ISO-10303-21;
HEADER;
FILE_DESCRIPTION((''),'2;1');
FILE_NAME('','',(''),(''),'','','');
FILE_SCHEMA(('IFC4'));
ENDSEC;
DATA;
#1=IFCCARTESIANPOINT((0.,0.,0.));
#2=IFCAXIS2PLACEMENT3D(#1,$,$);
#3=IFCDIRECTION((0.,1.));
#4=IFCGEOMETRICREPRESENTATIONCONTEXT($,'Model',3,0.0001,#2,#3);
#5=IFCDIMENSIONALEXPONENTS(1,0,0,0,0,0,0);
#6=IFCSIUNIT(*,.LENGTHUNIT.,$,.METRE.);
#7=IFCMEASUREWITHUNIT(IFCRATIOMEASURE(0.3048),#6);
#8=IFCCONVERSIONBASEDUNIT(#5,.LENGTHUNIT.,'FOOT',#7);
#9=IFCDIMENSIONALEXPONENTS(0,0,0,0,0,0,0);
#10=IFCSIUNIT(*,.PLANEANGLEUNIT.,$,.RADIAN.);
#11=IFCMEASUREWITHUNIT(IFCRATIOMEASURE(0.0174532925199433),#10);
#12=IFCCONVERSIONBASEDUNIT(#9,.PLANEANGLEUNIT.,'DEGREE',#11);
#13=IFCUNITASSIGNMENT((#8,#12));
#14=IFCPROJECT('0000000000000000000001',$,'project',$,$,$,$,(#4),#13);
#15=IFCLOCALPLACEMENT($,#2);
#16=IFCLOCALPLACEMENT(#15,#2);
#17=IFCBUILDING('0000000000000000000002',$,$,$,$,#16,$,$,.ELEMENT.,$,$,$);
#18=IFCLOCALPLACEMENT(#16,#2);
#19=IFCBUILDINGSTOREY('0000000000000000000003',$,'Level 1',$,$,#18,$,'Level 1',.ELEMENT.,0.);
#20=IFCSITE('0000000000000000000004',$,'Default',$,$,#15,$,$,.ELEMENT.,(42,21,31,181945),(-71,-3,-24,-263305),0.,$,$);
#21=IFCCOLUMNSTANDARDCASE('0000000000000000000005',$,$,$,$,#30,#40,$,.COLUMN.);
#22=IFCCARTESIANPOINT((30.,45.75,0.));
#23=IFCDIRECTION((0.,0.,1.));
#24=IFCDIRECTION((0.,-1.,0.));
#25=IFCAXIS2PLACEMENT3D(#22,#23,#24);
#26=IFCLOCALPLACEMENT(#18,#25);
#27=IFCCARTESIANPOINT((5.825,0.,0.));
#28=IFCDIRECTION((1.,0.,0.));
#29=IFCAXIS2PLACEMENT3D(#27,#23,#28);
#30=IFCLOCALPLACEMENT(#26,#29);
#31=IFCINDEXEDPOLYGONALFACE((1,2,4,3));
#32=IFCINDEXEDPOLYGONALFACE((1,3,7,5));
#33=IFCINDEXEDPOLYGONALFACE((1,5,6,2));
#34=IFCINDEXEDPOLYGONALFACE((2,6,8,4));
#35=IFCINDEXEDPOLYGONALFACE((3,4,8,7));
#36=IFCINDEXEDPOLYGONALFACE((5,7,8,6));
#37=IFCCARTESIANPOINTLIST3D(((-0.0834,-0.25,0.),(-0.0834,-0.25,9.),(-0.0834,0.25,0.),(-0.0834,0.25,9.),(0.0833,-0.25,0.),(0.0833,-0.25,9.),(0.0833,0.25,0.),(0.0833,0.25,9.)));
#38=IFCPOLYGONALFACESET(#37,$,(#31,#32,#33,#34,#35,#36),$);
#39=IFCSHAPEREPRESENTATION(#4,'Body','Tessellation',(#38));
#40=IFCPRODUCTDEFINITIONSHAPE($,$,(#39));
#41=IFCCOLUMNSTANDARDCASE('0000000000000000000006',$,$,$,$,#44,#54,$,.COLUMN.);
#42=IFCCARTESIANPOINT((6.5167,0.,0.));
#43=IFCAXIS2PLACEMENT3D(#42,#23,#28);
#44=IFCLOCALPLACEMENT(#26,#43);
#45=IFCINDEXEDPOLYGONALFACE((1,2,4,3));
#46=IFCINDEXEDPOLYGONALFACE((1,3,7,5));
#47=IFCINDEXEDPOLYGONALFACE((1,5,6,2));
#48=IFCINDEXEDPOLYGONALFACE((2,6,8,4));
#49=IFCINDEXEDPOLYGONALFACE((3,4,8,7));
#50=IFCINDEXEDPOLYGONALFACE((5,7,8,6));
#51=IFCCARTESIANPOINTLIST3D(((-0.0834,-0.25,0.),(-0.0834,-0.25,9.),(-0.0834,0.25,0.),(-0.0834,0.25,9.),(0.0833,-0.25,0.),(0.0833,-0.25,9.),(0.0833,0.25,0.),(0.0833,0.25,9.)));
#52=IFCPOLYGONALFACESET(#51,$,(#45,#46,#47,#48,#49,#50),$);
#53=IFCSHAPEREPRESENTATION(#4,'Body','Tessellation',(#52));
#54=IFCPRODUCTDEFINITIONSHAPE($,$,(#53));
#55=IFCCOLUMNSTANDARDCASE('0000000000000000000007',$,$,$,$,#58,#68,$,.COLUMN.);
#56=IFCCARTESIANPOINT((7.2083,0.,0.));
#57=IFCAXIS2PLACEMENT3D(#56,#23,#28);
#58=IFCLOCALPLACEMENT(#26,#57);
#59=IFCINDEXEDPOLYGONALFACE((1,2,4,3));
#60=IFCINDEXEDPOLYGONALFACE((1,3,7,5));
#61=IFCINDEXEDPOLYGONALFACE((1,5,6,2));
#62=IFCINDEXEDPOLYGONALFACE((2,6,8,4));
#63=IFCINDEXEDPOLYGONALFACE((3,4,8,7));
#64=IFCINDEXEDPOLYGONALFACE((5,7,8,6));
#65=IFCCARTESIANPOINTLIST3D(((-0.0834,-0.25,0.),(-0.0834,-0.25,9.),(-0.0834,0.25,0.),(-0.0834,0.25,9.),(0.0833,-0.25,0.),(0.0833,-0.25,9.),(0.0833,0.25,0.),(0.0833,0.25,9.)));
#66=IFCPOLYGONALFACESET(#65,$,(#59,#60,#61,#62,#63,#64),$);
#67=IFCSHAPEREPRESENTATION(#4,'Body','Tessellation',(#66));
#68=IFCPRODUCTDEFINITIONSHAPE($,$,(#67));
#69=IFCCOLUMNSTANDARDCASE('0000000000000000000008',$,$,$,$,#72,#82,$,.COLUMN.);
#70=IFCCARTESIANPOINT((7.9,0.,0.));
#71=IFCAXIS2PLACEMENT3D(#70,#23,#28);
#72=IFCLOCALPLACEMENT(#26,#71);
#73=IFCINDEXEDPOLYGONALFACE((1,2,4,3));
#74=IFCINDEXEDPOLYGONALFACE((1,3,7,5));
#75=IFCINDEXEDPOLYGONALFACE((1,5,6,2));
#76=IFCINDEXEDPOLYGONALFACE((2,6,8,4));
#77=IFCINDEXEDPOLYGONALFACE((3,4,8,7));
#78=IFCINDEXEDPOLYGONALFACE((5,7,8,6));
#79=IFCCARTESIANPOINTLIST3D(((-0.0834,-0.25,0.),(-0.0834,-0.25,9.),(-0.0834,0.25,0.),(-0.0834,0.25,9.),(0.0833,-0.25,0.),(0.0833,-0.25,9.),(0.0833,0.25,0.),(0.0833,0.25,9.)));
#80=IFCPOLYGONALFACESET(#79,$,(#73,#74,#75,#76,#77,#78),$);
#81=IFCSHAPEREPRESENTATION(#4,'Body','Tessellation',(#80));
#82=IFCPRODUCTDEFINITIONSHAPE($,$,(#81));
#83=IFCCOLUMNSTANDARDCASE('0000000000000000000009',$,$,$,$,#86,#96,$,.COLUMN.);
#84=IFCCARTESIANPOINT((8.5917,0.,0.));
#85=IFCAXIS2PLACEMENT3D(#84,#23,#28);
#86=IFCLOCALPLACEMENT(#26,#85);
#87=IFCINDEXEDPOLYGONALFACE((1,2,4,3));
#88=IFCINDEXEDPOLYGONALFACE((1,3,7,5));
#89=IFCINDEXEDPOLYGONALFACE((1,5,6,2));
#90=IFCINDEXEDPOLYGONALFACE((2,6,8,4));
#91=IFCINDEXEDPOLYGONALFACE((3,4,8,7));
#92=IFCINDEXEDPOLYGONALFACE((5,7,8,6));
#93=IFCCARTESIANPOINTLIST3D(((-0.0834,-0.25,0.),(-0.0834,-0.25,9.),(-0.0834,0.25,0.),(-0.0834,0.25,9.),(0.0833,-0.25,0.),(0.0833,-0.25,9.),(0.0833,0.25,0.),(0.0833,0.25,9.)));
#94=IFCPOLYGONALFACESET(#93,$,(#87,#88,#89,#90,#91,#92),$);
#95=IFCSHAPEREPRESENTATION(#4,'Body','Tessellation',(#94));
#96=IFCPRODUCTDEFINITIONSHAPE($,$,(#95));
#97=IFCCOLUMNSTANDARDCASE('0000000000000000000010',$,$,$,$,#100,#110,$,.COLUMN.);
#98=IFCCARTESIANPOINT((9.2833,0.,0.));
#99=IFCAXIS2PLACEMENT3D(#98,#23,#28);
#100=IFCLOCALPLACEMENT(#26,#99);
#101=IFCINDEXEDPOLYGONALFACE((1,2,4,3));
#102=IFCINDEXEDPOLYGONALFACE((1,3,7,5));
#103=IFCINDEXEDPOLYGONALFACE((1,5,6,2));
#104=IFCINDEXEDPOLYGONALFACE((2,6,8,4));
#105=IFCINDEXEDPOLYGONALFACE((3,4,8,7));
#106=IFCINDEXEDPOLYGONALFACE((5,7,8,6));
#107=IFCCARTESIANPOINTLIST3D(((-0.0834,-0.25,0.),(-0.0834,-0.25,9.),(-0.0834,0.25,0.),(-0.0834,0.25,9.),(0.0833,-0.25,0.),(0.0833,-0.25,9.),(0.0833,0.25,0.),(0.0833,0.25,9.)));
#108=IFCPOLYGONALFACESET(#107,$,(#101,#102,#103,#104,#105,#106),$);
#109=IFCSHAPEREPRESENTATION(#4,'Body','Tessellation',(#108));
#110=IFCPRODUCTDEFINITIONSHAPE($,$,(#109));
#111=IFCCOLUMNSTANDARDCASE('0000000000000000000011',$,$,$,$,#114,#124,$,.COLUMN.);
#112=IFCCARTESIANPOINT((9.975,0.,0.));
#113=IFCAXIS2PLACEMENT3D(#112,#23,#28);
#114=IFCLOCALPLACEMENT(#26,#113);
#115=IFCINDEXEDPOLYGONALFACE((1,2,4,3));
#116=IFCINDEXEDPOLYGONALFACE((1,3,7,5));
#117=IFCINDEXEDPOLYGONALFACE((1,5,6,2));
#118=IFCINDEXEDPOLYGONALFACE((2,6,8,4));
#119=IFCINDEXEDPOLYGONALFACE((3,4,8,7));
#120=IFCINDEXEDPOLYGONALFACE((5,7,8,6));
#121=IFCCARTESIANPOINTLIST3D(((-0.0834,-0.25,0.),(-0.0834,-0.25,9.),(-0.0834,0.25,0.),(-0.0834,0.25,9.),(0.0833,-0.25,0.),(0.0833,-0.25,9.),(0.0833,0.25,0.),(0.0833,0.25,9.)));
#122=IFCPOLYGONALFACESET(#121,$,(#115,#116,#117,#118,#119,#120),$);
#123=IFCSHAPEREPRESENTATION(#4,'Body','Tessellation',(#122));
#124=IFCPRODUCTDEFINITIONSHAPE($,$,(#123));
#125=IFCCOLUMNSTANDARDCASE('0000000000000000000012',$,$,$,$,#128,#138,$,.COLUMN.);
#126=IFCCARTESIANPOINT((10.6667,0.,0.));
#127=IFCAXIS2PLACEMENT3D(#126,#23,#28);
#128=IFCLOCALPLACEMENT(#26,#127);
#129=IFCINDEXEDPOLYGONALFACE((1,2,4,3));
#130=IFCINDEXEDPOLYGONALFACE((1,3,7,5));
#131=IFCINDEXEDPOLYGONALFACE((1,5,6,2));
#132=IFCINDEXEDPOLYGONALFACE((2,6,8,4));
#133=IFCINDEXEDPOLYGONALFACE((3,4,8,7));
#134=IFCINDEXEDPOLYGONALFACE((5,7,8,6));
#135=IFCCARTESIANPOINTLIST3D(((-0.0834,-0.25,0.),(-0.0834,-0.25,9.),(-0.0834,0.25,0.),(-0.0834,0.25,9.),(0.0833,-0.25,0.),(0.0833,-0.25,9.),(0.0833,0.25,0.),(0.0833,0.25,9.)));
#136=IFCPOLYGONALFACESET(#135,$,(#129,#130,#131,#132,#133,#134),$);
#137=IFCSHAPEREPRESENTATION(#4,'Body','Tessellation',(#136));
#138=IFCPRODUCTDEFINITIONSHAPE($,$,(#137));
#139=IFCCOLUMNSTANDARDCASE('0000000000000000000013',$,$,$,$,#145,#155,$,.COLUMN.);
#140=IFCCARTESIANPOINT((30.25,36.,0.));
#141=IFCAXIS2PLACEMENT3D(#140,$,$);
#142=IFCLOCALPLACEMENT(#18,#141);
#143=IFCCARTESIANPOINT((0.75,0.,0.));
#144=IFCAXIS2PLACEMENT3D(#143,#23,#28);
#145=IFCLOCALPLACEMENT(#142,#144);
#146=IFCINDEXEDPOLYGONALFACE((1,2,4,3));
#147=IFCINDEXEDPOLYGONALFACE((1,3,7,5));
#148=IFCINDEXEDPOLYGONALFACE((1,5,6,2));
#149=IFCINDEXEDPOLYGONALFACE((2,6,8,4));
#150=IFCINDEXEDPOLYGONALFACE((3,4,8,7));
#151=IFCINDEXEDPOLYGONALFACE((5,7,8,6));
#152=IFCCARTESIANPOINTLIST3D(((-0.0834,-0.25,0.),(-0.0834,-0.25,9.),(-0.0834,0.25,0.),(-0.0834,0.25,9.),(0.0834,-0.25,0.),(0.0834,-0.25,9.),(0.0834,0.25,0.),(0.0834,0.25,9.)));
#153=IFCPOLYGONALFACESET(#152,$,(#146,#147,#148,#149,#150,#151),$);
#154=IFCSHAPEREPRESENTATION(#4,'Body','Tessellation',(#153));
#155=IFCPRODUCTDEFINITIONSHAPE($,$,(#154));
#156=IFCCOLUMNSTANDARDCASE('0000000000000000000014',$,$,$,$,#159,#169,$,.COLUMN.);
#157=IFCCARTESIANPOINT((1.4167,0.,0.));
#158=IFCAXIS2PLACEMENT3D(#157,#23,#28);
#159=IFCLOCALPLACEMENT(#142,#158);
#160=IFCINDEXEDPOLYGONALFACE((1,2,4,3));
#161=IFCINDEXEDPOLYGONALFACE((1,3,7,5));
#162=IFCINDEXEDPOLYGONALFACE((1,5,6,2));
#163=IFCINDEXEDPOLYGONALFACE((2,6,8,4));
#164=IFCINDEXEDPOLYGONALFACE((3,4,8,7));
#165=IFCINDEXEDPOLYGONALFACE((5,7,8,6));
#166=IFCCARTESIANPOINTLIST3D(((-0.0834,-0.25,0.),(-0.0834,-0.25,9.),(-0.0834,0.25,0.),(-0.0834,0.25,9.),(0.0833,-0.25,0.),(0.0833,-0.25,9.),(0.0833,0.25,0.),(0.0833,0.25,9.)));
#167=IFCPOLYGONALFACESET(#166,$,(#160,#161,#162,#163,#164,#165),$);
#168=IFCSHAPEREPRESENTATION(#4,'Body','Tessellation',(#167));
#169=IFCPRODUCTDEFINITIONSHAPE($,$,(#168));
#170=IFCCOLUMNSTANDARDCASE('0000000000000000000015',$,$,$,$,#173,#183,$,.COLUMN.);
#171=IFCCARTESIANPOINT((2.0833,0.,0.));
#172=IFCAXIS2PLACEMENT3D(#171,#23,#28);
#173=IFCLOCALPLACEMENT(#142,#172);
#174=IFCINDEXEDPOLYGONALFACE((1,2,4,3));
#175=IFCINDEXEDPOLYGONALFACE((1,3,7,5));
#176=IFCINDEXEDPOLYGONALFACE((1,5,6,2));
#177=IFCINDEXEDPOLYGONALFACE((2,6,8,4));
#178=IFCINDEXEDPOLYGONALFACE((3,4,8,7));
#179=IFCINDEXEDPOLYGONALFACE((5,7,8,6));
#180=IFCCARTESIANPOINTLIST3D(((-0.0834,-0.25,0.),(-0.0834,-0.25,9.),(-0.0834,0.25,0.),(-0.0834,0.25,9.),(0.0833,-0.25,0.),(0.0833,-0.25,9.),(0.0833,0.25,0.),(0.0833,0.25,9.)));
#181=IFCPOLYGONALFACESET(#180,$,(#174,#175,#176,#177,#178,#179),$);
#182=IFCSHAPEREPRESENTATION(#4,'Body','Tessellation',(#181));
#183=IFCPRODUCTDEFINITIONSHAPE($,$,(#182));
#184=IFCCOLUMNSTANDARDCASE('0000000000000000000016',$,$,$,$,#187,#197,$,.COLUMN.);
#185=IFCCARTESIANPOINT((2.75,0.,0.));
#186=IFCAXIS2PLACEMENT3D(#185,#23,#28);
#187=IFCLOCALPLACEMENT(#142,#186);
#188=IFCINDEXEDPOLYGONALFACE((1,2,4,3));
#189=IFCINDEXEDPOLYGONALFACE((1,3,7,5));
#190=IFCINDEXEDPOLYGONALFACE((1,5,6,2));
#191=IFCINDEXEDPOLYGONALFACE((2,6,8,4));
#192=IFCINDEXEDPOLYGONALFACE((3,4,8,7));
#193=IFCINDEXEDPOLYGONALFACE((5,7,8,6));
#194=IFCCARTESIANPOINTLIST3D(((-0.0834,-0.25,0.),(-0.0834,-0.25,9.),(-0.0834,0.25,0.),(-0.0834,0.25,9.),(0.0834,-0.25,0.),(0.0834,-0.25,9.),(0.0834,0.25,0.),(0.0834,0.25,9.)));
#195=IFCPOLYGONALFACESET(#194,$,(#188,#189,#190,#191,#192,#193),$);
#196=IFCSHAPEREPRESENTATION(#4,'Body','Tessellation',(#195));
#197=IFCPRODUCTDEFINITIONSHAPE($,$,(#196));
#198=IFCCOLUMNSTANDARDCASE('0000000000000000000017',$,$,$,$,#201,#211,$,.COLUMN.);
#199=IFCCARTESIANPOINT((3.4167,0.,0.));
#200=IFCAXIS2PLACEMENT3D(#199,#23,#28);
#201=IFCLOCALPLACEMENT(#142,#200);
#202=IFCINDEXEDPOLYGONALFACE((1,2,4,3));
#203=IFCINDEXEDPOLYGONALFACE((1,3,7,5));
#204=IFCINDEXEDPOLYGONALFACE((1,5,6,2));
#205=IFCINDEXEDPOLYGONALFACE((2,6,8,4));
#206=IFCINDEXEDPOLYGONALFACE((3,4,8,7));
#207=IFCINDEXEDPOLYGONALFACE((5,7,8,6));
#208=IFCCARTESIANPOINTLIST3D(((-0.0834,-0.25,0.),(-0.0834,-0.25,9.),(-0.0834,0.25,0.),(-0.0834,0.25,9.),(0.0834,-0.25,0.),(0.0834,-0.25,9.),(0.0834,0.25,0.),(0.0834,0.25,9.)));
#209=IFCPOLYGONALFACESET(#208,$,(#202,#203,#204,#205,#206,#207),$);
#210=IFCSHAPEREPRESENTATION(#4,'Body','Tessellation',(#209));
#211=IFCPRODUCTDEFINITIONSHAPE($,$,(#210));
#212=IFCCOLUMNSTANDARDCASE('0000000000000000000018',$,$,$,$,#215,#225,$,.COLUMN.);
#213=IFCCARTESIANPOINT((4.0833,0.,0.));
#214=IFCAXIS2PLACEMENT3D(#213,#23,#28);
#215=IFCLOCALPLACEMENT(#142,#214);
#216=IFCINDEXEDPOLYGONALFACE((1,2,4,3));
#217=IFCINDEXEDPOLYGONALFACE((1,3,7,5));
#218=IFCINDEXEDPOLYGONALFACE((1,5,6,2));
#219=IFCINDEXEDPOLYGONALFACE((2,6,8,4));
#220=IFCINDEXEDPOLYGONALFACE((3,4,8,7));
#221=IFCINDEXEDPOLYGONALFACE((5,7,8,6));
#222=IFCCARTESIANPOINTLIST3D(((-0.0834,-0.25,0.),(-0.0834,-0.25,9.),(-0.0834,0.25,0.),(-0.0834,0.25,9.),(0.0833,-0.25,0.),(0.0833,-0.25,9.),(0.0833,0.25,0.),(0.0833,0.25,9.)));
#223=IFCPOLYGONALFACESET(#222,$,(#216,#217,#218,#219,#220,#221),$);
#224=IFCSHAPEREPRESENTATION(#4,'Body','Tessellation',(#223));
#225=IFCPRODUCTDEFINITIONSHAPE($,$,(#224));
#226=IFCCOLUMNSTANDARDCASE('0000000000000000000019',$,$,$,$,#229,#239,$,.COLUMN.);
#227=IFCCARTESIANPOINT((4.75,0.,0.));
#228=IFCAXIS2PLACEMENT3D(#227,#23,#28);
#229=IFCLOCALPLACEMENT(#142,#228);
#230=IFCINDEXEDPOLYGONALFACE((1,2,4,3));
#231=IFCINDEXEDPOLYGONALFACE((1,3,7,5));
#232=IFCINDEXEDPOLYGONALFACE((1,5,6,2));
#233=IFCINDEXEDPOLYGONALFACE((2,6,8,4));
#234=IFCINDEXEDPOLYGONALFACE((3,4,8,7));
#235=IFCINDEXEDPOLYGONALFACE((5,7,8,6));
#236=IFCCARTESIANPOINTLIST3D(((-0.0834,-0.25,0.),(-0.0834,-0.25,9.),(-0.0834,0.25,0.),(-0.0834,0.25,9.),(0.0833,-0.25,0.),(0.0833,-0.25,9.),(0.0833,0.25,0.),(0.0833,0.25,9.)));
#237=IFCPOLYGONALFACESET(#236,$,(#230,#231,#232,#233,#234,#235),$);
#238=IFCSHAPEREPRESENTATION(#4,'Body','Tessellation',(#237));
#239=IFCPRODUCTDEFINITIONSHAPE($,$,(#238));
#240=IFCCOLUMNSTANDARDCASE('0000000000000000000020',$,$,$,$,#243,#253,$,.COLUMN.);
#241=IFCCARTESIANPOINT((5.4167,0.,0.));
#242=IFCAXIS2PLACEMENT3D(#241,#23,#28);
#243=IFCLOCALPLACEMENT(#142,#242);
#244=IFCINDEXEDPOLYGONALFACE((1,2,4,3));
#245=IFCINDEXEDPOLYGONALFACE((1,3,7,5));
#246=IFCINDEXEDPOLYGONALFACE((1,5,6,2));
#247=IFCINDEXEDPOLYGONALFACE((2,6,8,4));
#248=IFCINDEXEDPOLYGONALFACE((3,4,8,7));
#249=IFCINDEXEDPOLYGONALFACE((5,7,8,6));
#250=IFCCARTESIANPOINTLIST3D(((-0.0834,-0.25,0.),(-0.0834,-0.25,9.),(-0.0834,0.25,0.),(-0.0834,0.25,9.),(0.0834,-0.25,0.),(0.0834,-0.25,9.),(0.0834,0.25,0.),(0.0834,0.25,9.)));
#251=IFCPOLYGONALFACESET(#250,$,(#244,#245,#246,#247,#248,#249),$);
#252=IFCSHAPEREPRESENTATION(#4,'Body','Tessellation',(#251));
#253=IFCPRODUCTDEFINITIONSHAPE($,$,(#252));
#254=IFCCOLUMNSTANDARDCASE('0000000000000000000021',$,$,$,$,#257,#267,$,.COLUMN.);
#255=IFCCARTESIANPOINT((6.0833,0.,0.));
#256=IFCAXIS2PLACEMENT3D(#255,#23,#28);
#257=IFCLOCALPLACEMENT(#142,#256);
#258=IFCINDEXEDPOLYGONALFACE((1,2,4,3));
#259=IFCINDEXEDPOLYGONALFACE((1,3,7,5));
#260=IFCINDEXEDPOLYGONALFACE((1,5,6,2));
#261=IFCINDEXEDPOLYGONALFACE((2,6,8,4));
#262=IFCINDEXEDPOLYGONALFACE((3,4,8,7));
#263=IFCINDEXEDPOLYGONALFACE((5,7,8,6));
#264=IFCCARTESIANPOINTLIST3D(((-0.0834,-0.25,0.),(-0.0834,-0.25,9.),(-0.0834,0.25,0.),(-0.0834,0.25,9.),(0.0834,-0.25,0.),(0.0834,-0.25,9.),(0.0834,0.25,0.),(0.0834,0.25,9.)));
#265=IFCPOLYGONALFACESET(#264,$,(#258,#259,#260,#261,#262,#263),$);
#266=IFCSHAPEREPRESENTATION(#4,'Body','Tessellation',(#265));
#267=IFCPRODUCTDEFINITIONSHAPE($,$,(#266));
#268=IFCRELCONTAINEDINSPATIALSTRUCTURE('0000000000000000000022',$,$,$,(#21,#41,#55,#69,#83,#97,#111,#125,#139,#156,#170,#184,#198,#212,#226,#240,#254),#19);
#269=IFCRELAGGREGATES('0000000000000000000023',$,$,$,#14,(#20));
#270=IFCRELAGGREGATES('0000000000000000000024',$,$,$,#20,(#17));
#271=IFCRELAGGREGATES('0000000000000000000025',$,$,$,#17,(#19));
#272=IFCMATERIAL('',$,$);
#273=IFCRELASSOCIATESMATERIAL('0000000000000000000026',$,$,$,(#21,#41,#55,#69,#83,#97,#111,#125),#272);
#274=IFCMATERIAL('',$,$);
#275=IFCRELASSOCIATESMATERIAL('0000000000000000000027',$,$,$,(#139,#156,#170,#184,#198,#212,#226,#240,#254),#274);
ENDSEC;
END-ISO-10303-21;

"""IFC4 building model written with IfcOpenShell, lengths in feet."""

from ifc_helpers import new_model, entity, si_unit, converted_unit, direction, frame, origin, place, context, project, spatial, rectangle, extrude, material, element, save


model = new_model("IFC4")

# Units and contexts
model_context = context("Model", 3, precision=0.0001, world=origin(), true_north=direction((0.0, 1.0)))
ifc_project = project(units=[converted_unit("LENGTHUNIT", "FOOT", entity("IfcRatioMeasure", 0.3048), si_unit("LENGTHUNIT", "METRE"), dimensions=[1, 0, 0, 0, 0, 0, 0]), converted_unit("PLANEANGLEUNIT", "DEGREE", entity("IfcRatioMeasure", 0.0174532925199433), si_unit("PLANEANGLEUNIT", "RADIAN"), dimensions=[0, 0, 0, 0, 0, 0, 0])], contexts=[model_context])

# Site, building, storey
site_placement = place(None, origin())
site = spatial("IfcSite", under=ifc_project, at=site_placement, Name="Default", CompositionType="ELEMENT", RefLatitude=(42, 21, 31, 181945), RefLongitude=(-71, -3, -24, -263305), RefElevation=0.0)
building_placement = place(site_placement, origin())
building = spatial("IfcBuilding", under=site, at=building_placement, CompositionType="ELEMENT")
storey_placement = place(building_placement, origin())
storey = spatial("IfcBuildingStorey", under=building, at=storey_placement, Name="Level 1", LongName="Level 1", CompositionType="ELEMENT", Elevation=0.0)

# Columns
ifc_material_1 = material(Name="")
placement_1 = place(storey_placement, frame((30.0, 45.75, 0.0), z_axis=(0.0, 0.0, 1.0), x_axis=(0.0, -1.0, 0.0)))
for number, where, z_axis, x_axis in (
    (1, (5.825, 0.0, 0.0), (0.0, 0.0, 1.0), (1.0, 0.0, 0.0)),
    (2, (6.5167, 0.0, 0.0), (0.0, 0.0, 1.0), (1.0, 0.0, 0.0)),
    (3, (7.2083, 0.0, 0.0), (0.0, 0.0, 1.0), (1.0, 0.0, 0.0)),
    (4, (7.9, 0.0, 0.0), (0.0, 0.0, 1.0), (1.0, 0.0, 0.0)),
    (5, (8.5917, 0.0, 0.0), (0.0, 0.0, 1.0), (1.0, 0.0, 0.0)),
    (6, (9.2833, 0.0, 0.0), (0.0, 0.0, 1.0), (1.0, 0.0, 0.0)),
    (7, (9.975, 0.0, 0.0), (0.0, 0.0, 1.0), (1.0, 0.0, 0.0)),
    (8, (10.6667, 0.0, 0.0), (0.0, 0.0, 1.0), (1.0, 0.0, 0.0)),
):
    element("IfcColumnStandardCase", number, at=place(placement_1, frame(where, z_axis=z_axis, x_axis=x_axis)), inside=storey, material=ifc_material_1, PredefinedType="COLUMN", context=model_context, shape_type="SweptSolid", body=[
        extrude(rectangle(XDim=0.1667, YDim=0.5), origin(), (0.0, 0.0, 1.0), 9.0),
    ])
ifc_material_2 = material(Name="")
placement_2 = place(storey_placement, frame((30.25, 36.0, 0.0)))
for number, where, z_axis, x_axis in (
    (9, (0.75, 0.0, 0.0), (0.0, 0.0, 1.0), (1.0, 0.0, 0.0)),
    (10, (1.4167, 0.0, 0.0), (0.0, 0.0, 1.0), (1.0, 0.0, 0.0)),
    (11, (2.0833, 0.0, 0.0), (0.0, 0.0, 1.0), (1.0, 0.0, 0.0)),
    (12, (2.75, 0.0, 0.0), (0.0, 0.0, 1.0), (1.0, 0.0, 0.0)),
    (13, (3.4167, 0.0, 0.0), (0.0, 0.0, 1.0), (1.0, 0.0, 0.0)),
    (14, (4.0833, 0.0, 0.0), (0.0, 0.0, 1.0), (1.0, 0.0, 0.0)),
    (15, (4.75, 0.0, 0.0), (0.0, 0.0, 1.0), (1.0, 0.0, 0.0)),
    (16, (5.4167, 0.0, 0.0), (0.0, 0.0, 1.0), (1.0, 0.0, 0.0)),
    (17, (6.0833, 0.0, 0.0), (0.0, 0.0, 1.0), (1.0, 0.0, 0.0)),
):
    element("IfcColumnStandardCase", number, at=place(placement_2, frame(where, z_axis=z_axis, x_axis=x_axis)), inside=storey, material=ifc_material_2, PredefinedType="COLUMN", context=model_context, shape_type="SweptSolid", body=[
        extrude(rectangle(XDim=0.1667, YDim=0.5), origin(), (0.0, 0.0, 1.0), 9.0),
    ])

save(model, "model.ifc")
